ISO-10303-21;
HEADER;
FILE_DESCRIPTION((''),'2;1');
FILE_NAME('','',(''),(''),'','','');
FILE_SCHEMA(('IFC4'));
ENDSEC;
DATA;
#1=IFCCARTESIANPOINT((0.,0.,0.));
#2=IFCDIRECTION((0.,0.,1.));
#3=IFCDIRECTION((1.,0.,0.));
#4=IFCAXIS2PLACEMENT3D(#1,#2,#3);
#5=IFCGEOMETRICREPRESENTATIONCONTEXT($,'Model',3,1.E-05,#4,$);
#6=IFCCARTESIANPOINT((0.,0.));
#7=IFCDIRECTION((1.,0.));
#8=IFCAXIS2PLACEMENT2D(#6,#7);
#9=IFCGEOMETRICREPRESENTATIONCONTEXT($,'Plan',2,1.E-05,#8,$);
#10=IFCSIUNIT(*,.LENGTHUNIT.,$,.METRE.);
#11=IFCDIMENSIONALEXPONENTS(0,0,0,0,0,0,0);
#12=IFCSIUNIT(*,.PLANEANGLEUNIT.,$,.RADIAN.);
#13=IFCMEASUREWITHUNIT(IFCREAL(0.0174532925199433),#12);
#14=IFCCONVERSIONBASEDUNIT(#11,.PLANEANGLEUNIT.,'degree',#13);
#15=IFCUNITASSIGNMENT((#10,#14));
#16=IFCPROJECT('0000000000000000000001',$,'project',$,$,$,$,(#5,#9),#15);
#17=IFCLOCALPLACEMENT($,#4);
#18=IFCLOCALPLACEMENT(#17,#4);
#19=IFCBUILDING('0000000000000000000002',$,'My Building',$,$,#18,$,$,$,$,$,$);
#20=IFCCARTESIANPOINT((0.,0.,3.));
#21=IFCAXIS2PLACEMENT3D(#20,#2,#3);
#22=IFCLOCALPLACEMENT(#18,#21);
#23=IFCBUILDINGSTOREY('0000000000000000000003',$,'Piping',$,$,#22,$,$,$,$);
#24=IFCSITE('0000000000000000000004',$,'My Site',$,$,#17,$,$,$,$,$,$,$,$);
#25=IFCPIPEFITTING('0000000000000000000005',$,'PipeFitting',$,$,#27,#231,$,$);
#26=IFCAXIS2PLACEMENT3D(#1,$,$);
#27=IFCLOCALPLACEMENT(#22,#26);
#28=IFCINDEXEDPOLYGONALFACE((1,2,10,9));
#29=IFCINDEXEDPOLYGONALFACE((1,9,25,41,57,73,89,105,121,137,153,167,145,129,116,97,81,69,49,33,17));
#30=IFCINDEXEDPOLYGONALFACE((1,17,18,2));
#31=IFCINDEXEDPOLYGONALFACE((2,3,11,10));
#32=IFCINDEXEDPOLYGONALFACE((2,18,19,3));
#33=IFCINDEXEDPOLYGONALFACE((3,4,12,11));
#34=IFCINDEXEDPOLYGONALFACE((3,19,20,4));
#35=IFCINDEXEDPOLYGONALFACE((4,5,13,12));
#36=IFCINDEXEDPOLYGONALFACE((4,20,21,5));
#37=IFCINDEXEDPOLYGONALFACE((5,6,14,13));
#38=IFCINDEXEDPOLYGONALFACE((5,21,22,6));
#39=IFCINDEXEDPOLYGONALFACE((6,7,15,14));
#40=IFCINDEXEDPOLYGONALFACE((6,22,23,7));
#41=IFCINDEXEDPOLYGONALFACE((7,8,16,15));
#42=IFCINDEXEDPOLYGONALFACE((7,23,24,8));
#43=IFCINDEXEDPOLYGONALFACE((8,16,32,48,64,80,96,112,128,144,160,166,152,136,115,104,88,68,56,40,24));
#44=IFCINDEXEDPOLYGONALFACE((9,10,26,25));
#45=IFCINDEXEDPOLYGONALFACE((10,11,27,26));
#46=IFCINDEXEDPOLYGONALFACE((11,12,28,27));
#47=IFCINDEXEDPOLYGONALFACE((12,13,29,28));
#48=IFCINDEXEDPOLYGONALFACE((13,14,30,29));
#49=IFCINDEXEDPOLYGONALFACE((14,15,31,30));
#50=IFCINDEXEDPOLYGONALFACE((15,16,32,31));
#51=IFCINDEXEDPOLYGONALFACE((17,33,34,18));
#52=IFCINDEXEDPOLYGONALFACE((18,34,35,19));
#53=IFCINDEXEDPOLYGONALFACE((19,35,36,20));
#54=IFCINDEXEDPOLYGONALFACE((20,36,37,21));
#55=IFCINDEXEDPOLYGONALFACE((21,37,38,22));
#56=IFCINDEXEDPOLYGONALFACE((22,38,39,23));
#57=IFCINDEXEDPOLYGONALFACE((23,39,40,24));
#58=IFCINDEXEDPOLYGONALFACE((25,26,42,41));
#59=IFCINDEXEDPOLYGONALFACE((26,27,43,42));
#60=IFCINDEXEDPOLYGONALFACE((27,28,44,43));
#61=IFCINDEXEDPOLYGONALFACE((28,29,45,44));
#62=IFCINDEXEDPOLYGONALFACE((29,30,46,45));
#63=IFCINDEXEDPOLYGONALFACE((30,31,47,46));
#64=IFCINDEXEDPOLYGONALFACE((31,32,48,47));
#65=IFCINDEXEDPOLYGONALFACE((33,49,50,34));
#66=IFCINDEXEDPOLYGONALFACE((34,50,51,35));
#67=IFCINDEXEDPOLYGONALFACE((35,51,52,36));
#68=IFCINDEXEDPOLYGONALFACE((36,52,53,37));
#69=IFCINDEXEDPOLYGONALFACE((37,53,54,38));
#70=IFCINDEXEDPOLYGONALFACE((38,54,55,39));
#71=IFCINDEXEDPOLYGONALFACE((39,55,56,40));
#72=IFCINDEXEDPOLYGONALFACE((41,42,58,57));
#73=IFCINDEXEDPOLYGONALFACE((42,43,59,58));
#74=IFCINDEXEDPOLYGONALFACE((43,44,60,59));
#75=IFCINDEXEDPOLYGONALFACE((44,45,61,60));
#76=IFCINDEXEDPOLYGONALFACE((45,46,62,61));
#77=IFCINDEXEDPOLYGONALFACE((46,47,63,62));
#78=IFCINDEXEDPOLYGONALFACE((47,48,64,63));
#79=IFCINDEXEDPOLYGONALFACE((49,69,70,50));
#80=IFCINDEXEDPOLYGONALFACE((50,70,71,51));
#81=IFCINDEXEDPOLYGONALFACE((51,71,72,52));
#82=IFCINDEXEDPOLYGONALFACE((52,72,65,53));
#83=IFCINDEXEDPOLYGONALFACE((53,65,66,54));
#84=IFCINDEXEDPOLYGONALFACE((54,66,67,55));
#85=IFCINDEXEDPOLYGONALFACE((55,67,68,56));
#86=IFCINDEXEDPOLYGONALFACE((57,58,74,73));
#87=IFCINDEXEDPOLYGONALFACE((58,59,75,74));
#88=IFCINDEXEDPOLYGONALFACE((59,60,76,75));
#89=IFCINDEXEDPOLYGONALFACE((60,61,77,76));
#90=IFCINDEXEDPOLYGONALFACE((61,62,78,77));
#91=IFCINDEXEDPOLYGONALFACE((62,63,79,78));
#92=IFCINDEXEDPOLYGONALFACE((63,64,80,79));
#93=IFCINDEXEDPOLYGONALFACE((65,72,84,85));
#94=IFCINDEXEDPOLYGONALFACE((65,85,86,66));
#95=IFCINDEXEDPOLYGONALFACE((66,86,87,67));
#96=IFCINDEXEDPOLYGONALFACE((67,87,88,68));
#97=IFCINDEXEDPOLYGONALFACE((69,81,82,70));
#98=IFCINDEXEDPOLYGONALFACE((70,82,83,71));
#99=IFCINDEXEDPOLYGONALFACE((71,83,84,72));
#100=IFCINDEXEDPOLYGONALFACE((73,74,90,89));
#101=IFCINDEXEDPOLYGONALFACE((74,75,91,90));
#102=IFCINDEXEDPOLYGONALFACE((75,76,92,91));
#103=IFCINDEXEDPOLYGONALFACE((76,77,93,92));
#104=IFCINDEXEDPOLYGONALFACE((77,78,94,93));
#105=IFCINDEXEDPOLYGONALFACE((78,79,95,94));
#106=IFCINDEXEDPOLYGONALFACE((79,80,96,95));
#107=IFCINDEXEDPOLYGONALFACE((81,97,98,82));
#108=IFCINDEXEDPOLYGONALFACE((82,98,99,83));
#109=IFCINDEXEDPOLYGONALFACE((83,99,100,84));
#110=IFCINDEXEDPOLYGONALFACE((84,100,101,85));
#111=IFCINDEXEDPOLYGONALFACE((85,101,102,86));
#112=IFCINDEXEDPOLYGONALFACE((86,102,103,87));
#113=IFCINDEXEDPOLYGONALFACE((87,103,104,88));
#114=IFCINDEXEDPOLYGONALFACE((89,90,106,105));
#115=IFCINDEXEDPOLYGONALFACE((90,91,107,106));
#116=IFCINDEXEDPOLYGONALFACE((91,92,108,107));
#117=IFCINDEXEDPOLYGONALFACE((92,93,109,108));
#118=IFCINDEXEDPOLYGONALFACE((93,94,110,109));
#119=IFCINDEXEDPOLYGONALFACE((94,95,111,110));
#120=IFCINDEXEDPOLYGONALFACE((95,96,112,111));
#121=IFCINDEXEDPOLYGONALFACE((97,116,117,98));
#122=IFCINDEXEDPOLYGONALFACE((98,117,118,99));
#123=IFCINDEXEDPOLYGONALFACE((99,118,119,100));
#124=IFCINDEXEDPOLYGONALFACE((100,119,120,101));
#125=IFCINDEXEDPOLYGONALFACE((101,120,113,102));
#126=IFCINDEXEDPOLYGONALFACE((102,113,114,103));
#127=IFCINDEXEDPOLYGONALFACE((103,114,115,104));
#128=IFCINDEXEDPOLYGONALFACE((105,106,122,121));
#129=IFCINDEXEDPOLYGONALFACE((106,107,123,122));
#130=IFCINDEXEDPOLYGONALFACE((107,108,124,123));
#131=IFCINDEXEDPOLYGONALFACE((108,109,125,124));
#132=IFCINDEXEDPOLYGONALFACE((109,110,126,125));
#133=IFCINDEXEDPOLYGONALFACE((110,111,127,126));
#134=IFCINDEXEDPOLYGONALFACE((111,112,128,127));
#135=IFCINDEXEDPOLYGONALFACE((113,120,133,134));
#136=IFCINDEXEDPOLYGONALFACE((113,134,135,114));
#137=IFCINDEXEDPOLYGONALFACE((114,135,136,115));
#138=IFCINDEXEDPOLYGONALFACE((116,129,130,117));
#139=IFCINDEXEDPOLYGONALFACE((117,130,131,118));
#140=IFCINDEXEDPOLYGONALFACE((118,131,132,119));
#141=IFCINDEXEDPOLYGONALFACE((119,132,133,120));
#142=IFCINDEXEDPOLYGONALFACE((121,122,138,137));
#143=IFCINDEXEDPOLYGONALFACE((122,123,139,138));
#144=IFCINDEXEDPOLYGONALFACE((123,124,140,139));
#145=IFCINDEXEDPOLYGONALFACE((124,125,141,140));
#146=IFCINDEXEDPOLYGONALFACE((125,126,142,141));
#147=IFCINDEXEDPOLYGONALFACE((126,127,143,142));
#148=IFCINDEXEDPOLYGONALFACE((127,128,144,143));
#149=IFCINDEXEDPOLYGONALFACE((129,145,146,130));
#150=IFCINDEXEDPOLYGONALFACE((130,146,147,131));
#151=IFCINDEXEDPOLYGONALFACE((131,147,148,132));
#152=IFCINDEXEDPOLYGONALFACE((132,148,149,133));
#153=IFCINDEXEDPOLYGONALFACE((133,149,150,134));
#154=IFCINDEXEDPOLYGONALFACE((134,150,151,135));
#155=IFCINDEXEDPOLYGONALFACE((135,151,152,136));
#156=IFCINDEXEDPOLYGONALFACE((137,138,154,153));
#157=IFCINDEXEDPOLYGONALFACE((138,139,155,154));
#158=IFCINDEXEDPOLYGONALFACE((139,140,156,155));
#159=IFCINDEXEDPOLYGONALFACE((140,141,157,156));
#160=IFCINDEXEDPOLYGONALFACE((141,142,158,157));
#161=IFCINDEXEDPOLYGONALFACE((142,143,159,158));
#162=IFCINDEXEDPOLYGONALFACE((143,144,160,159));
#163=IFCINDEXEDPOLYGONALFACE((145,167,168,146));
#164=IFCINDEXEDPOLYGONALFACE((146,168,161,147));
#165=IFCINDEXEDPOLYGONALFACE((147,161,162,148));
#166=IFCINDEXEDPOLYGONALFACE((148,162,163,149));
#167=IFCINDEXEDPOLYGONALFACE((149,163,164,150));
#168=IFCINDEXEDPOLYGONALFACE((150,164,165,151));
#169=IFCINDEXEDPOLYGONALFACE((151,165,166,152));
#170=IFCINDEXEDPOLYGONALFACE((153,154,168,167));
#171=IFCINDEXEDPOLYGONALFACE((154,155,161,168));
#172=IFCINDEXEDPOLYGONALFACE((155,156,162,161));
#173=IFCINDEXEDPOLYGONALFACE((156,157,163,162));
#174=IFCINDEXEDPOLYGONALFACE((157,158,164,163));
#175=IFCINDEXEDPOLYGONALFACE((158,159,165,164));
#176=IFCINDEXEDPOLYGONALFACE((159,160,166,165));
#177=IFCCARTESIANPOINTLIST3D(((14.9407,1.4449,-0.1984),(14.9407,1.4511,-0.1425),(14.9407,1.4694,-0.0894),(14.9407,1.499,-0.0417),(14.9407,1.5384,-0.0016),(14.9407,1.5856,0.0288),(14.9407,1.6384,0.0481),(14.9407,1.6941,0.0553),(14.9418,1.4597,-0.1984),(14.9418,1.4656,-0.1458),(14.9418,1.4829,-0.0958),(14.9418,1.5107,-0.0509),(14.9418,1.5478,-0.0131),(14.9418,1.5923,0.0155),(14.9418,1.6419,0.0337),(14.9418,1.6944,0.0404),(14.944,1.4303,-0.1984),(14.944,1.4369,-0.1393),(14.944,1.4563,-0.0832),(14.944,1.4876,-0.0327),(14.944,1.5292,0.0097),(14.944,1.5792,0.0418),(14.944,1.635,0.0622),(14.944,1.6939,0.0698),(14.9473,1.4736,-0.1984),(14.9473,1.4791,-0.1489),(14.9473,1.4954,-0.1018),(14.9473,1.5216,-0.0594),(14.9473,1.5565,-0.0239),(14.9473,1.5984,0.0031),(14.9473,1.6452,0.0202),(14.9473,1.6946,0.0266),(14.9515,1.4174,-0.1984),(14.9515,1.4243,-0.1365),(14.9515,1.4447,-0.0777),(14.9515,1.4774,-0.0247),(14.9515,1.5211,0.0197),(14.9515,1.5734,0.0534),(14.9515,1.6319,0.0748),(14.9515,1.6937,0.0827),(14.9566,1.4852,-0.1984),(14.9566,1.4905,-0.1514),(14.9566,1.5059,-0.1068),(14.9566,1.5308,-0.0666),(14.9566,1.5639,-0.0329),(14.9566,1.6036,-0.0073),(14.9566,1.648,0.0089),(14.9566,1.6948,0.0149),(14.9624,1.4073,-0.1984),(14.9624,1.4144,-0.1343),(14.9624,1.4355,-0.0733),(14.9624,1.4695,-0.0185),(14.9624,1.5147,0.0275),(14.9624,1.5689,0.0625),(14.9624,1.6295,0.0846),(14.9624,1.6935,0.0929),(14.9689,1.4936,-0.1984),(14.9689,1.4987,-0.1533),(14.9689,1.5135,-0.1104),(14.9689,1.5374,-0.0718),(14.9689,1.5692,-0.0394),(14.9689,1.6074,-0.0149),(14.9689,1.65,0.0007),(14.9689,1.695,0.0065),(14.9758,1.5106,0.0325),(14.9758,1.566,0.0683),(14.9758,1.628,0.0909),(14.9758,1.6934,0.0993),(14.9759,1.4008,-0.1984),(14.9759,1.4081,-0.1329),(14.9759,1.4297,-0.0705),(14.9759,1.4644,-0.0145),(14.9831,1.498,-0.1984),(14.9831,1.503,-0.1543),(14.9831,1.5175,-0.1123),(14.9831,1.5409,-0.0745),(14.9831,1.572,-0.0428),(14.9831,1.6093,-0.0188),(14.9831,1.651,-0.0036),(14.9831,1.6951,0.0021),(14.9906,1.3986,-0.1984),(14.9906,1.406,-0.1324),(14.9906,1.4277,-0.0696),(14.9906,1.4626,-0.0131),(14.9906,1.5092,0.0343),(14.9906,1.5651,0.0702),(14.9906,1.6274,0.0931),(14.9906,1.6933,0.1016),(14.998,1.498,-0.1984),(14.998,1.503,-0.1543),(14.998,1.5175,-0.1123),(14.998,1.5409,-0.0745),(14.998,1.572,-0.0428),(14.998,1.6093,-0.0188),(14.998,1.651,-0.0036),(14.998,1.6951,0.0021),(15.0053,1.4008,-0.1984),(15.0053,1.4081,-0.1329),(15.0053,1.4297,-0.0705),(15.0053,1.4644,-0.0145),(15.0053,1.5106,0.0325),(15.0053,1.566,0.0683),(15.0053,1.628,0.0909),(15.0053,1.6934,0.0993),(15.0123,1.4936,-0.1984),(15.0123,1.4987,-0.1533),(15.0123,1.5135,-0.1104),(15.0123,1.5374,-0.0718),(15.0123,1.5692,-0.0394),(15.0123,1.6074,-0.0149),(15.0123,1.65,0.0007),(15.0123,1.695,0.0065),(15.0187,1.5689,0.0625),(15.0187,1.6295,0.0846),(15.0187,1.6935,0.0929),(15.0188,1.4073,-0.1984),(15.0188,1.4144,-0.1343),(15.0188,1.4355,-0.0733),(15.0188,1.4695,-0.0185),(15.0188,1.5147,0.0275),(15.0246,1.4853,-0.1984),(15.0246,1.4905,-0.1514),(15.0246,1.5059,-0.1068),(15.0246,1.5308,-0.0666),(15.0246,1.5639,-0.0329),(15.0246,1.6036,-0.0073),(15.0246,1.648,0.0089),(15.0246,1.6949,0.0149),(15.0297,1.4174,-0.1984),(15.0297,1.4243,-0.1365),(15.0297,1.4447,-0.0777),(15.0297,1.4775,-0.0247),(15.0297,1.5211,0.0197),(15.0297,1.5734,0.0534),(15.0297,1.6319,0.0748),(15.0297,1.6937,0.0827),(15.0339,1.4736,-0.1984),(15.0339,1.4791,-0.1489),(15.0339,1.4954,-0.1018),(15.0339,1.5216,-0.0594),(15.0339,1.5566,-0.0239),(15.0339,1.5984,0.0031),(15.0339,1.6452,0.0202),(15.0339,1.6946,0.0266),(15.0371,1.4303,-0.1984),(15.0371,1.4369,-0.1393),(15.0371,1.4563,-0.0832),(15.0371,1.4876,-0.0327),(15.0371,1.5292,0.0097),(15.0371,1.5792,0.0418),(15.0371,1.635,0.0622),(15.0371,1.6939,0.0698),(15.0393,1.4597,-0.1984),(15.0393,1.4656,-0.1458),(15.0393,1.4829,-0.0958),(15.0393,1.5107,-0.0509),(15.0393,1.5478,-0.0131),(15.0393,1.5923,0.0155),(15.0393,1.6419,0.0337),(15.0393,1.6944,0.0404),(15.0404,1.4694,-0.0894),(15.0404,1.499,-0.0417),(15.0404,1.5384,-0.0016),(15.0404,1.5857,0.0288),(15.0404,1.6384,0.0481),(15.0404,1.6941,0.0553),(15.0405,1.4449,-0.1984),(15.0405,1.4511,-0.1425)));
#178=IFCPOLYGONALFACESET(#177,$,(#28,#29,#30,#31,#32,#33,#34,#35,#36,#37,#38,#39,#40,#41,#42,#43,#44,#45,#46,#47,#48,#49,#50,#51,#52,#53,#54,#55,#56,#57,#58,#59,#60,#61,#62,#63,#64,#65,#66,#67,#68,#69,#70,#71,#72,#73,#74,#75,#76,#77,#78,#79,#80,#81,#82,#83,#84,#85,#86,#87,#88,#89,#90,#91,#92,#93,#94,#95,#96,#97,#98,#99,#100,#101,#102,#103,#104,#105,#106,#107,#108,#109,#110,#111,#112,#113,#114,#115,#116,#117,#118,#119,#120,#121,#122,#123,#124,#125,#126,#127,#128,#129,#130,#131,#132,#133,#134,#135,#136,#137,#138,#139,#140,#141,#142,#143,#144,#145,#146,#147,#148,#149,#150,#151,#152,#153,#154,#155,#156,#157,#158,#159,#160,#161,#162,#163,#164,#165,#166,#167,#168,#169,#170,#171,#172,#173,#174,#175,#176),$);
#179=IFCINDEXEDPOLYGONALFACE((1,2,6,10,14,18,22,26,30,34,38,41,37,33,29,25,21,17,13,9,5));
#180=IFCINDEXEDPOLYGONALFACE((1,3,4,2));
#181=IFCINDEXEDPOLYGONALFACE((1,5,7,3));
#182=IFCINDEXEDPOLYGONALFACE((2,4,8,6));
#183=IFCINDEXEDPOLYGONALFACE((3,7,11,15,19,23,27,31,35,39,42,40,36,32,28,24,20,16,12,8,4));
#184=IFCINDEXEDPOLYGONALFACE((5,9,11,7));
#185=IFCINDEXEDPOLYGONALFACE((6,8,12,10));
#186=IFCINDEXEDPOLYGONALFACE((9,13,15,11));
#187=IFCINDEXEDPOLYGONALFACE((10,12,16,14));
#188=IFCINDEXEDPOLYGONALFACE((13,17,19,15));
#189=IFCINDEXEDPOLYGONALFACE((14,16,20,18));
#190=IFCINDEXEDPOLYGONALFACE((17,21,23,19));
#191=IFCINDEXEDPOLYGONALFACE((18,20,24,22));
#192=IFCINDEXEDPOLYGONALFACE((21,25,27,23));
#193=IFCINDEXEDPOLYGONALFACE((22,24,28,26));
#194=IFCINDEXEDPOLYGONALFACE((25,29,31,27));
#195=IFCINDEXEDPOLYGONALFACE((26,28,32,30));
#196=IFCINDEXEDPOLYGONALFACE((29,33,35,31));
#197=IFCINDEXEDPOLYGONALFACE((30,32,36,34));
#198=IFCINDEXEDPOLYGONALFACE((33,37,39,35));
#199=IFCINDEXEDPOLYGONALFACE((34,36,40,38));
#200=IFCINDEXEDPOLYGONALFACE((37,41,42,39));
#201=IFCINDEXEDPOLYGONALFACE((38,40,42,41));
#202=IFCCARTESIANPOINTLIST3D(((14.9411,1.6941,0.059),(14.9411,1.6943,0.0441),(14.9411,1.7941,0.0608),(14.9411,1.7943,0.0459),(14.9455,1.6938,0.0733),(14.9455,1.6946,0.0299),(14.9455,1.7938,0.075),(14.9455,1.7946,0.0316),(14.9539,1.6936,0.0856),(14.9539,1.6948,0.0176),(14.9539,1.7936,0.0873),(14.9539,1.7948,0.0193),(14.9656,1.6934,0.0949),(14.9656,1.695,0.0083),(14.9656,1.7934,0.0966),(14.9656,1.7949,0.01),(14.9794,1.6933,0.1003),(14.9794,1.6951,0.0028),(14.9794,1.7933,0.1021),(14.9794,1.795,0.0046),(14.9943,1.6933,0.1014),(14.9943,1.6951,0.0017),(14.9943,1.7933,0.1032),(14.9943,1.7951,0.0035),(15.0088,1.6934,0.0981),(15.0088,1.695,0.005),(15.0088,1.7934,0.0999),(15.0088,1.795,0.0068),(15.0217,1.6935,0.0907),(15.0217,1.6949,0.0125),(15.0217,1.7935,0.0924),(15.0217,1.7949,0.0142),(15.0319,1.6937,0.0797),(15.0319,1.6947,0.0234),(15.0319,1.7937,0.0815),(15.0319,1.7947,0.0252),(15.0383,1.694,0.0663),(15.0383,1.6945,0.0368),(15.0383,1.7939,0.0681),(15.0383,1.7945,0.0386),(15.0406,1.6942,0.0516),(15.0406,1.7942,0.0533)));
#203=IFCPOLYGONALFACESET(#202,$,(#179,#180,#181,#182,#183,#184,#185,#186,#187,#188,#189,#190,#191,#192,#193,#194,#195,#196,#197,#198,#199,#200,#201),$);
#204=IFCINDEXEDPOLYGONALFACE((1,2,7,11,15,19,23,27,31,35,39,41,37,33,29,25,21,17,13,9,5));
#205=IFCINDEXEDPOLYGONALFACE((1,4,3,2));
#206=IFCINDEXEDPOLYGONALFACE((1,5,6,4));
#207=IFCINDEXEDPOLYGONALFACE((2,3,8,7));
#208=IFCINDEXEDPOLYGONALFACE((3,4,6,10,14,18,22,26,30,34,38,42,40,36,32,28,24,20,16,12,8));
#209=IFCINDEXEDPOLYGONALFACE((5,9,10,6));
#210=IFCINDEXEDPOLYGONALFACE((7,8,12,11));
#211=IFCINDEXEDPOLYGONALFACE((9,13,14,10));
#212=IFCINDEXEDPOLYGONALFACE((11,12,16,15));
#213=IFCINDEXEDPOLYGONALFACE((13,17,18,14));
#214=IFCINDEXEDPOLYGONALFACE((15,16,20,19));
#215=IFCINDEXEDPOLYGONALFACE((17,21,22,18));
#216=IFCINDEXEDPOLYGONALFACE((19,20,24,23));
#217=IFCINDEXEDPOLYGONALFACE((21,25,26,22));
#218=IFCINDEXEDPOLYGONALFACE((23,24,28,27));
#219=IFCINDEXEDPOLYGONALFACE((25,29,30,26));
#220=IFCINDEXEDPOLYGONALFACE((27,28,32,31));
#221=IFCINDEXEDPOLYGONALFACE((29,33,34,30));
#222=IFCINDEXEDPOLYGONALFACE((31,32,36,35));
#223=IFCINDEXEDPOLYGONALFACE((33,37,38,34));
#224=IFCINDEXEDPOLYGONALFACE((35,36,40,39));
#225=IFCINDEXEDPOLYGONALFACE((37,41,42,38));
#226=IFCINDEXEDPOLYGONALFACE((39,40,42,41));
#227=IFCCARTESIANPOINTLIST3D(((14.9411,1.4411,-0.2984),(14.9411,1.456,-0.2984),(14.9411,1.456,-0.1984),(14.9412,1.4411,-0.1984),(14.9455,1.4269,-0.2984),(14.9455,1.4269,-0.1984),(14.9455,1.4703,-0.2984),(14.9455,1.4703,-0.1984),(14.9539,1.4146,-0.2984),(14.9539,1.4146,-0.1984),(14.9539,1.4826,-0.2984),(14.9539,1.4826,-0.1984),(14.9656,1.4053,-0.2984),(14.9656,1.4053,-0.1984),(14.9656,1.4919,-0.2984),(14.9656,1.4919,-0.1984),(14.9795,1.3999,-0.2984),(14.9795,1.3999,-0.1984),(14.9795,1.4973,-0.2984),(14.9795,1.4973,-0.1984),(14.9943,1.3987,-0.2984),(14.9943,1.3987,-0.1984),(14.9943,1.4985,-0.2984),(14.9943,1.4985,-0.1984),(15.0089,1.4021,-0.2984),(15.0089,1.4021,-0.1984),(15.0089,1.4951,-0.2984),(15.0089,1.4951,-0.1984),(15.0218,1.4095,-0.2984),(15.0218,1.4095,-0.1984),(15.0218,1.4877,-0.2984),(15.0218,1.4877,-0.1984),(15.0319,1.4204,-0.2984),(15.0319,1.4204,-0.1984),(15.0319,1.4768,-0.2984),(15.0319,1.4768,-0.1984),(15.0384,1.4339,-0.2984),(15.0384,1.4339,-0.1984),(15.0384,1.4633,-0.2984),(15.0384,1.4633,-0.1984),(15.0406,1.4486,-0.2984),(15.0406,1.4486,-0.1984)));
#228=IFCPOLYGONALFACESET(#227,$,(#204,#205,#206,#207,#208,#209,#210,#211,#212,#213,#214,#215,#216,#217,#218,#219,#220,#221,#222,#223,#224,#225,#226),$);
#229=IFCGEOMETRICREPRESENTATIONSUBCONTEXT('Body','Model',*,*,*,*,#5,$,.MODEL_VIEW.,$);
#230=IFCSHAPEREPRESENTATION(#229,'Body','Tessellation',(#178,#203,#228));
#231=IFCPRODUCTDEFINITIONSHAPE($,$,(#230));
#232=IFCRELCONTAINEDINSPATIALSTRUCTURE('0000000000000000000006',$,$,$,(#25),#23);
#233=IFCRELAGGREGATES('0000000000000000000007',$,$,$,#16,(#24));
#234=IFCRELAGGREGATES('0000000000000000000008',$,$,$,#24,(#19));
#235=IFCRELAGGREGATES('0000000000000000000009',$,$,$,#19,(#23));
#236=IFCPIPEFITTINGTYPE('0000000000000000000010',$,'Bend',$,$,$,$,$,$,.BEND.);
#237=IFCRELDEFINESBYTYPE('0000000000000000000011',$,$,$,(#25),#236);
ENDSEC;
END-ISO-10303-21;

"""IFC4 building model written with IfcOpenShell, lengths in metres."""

from ifc_helpers import new_model, entity, si_unit, converted_unit, frame, origin_with_axes, origin_2d_with_axis, place, context, subcontext, project, spatial, circle, extrude, source, transform, mapped, type_object, type_shapes, element, save


model = new_model("IFC4")

# Units and contexts
model_context = context("Model", 3, precision=1e-05, world=origin_with_axes())
plan_context = context("Plan", 2, precision=1e-05, world=origin_2d_with_axis())
body_context = subcontext(model_context, "Body", "Model", "MODEL_VIEW")
ifc_project = project(units=[si_unit("LENGTHUNIT", "METRE"), converted_unit("PLANEANGLEUNIT", "degree", entity("IfcReal", 0.0174532925199433), si_unit("PLANEANGLEUNIT", "RADIAN"), dimensions=[0, 0, 0, 0, 0, 0, 0])], contexts=[model_context, plan_context])

# Site, building, storey
site_placement = place(None, origin_with_axes())
site = spatial("IfcSite", under=ifc_project, at=site_placement, Name="My Site")
building_placement = place(site_placement, origin_with_axes())
building = spatial("IfcBuilding", under=site, at=building_placement, Name="My Building")
storey_placement = place(building_placement, frame((0.0, 0.0, 3.0), z_axis=(0.0, 0.0, 1.0), x_axis=(1.0, 0.0, 0.0)))
storey = spatial("IfcBuildingStorey", under=building, at=storey_placement, Name="Piping")

# Pipe fitting
pipe_fitting_type_1 = type_object("IfcPipeFittingType", Name="Bend", PredefinedType="BEND")
shared_shape_1 = source(origin_with_axes(), body_context, "Body", "SolidModel", [
    entity("IfcSweptDiskSolid", entity("IfcIndexedPolyCurve", entity("IfcCartesianPointList3D", [[0.0, 0.0, 0.1], [0.0, -0.0717, 0.2752], [0.0, -0.2456, 0.35]]), [entity("IfcArcIndex", [1, 2, 3])]), 0.05),
    extrude(circle(Radius=0.05), origin_with_axes(), (0.0, 0.0, 1.0), 0.1),
    extrude(circle(Radius=0.05), frame((0.0, -0.2456, 0.35), z_axis=(0.0, -0.999846, 0.017575), x_axis=(1.0, 0.0, 0.0)), (0.0, 0.0, 1.0), 0.1),
])
type_shapes(pipe_fitting_type_1, [shared_shape_1])
for number, where, z_axis, x_axis, name in (
    (1, (14.9906, 1.7942, 0.0533), (0.000099, -0.999846, -0.017575), (1.0, 0.000099, -0.000001), "PipeFitting"),
):
    element("IfcPipeFitting", number, at=place(storey_placement, frame(where, z_axis=z_axis, x_axis=x_axis)), inside=storey, type_object=pipe_fitting_type_1, Name=name, context=body_context, shape_type="MappedRepresentation", body=[
        mapped(shared_shape_1, transform((0.0, 0.0, 0.0), x_axis=(1.0, 0.0, 0.0), y_axis=(0.0, 1.0, 0.0), z_axis=(0.0, 0.0, 1.0), scale=1.0)),
    ])

save(model, "model.ifc")
